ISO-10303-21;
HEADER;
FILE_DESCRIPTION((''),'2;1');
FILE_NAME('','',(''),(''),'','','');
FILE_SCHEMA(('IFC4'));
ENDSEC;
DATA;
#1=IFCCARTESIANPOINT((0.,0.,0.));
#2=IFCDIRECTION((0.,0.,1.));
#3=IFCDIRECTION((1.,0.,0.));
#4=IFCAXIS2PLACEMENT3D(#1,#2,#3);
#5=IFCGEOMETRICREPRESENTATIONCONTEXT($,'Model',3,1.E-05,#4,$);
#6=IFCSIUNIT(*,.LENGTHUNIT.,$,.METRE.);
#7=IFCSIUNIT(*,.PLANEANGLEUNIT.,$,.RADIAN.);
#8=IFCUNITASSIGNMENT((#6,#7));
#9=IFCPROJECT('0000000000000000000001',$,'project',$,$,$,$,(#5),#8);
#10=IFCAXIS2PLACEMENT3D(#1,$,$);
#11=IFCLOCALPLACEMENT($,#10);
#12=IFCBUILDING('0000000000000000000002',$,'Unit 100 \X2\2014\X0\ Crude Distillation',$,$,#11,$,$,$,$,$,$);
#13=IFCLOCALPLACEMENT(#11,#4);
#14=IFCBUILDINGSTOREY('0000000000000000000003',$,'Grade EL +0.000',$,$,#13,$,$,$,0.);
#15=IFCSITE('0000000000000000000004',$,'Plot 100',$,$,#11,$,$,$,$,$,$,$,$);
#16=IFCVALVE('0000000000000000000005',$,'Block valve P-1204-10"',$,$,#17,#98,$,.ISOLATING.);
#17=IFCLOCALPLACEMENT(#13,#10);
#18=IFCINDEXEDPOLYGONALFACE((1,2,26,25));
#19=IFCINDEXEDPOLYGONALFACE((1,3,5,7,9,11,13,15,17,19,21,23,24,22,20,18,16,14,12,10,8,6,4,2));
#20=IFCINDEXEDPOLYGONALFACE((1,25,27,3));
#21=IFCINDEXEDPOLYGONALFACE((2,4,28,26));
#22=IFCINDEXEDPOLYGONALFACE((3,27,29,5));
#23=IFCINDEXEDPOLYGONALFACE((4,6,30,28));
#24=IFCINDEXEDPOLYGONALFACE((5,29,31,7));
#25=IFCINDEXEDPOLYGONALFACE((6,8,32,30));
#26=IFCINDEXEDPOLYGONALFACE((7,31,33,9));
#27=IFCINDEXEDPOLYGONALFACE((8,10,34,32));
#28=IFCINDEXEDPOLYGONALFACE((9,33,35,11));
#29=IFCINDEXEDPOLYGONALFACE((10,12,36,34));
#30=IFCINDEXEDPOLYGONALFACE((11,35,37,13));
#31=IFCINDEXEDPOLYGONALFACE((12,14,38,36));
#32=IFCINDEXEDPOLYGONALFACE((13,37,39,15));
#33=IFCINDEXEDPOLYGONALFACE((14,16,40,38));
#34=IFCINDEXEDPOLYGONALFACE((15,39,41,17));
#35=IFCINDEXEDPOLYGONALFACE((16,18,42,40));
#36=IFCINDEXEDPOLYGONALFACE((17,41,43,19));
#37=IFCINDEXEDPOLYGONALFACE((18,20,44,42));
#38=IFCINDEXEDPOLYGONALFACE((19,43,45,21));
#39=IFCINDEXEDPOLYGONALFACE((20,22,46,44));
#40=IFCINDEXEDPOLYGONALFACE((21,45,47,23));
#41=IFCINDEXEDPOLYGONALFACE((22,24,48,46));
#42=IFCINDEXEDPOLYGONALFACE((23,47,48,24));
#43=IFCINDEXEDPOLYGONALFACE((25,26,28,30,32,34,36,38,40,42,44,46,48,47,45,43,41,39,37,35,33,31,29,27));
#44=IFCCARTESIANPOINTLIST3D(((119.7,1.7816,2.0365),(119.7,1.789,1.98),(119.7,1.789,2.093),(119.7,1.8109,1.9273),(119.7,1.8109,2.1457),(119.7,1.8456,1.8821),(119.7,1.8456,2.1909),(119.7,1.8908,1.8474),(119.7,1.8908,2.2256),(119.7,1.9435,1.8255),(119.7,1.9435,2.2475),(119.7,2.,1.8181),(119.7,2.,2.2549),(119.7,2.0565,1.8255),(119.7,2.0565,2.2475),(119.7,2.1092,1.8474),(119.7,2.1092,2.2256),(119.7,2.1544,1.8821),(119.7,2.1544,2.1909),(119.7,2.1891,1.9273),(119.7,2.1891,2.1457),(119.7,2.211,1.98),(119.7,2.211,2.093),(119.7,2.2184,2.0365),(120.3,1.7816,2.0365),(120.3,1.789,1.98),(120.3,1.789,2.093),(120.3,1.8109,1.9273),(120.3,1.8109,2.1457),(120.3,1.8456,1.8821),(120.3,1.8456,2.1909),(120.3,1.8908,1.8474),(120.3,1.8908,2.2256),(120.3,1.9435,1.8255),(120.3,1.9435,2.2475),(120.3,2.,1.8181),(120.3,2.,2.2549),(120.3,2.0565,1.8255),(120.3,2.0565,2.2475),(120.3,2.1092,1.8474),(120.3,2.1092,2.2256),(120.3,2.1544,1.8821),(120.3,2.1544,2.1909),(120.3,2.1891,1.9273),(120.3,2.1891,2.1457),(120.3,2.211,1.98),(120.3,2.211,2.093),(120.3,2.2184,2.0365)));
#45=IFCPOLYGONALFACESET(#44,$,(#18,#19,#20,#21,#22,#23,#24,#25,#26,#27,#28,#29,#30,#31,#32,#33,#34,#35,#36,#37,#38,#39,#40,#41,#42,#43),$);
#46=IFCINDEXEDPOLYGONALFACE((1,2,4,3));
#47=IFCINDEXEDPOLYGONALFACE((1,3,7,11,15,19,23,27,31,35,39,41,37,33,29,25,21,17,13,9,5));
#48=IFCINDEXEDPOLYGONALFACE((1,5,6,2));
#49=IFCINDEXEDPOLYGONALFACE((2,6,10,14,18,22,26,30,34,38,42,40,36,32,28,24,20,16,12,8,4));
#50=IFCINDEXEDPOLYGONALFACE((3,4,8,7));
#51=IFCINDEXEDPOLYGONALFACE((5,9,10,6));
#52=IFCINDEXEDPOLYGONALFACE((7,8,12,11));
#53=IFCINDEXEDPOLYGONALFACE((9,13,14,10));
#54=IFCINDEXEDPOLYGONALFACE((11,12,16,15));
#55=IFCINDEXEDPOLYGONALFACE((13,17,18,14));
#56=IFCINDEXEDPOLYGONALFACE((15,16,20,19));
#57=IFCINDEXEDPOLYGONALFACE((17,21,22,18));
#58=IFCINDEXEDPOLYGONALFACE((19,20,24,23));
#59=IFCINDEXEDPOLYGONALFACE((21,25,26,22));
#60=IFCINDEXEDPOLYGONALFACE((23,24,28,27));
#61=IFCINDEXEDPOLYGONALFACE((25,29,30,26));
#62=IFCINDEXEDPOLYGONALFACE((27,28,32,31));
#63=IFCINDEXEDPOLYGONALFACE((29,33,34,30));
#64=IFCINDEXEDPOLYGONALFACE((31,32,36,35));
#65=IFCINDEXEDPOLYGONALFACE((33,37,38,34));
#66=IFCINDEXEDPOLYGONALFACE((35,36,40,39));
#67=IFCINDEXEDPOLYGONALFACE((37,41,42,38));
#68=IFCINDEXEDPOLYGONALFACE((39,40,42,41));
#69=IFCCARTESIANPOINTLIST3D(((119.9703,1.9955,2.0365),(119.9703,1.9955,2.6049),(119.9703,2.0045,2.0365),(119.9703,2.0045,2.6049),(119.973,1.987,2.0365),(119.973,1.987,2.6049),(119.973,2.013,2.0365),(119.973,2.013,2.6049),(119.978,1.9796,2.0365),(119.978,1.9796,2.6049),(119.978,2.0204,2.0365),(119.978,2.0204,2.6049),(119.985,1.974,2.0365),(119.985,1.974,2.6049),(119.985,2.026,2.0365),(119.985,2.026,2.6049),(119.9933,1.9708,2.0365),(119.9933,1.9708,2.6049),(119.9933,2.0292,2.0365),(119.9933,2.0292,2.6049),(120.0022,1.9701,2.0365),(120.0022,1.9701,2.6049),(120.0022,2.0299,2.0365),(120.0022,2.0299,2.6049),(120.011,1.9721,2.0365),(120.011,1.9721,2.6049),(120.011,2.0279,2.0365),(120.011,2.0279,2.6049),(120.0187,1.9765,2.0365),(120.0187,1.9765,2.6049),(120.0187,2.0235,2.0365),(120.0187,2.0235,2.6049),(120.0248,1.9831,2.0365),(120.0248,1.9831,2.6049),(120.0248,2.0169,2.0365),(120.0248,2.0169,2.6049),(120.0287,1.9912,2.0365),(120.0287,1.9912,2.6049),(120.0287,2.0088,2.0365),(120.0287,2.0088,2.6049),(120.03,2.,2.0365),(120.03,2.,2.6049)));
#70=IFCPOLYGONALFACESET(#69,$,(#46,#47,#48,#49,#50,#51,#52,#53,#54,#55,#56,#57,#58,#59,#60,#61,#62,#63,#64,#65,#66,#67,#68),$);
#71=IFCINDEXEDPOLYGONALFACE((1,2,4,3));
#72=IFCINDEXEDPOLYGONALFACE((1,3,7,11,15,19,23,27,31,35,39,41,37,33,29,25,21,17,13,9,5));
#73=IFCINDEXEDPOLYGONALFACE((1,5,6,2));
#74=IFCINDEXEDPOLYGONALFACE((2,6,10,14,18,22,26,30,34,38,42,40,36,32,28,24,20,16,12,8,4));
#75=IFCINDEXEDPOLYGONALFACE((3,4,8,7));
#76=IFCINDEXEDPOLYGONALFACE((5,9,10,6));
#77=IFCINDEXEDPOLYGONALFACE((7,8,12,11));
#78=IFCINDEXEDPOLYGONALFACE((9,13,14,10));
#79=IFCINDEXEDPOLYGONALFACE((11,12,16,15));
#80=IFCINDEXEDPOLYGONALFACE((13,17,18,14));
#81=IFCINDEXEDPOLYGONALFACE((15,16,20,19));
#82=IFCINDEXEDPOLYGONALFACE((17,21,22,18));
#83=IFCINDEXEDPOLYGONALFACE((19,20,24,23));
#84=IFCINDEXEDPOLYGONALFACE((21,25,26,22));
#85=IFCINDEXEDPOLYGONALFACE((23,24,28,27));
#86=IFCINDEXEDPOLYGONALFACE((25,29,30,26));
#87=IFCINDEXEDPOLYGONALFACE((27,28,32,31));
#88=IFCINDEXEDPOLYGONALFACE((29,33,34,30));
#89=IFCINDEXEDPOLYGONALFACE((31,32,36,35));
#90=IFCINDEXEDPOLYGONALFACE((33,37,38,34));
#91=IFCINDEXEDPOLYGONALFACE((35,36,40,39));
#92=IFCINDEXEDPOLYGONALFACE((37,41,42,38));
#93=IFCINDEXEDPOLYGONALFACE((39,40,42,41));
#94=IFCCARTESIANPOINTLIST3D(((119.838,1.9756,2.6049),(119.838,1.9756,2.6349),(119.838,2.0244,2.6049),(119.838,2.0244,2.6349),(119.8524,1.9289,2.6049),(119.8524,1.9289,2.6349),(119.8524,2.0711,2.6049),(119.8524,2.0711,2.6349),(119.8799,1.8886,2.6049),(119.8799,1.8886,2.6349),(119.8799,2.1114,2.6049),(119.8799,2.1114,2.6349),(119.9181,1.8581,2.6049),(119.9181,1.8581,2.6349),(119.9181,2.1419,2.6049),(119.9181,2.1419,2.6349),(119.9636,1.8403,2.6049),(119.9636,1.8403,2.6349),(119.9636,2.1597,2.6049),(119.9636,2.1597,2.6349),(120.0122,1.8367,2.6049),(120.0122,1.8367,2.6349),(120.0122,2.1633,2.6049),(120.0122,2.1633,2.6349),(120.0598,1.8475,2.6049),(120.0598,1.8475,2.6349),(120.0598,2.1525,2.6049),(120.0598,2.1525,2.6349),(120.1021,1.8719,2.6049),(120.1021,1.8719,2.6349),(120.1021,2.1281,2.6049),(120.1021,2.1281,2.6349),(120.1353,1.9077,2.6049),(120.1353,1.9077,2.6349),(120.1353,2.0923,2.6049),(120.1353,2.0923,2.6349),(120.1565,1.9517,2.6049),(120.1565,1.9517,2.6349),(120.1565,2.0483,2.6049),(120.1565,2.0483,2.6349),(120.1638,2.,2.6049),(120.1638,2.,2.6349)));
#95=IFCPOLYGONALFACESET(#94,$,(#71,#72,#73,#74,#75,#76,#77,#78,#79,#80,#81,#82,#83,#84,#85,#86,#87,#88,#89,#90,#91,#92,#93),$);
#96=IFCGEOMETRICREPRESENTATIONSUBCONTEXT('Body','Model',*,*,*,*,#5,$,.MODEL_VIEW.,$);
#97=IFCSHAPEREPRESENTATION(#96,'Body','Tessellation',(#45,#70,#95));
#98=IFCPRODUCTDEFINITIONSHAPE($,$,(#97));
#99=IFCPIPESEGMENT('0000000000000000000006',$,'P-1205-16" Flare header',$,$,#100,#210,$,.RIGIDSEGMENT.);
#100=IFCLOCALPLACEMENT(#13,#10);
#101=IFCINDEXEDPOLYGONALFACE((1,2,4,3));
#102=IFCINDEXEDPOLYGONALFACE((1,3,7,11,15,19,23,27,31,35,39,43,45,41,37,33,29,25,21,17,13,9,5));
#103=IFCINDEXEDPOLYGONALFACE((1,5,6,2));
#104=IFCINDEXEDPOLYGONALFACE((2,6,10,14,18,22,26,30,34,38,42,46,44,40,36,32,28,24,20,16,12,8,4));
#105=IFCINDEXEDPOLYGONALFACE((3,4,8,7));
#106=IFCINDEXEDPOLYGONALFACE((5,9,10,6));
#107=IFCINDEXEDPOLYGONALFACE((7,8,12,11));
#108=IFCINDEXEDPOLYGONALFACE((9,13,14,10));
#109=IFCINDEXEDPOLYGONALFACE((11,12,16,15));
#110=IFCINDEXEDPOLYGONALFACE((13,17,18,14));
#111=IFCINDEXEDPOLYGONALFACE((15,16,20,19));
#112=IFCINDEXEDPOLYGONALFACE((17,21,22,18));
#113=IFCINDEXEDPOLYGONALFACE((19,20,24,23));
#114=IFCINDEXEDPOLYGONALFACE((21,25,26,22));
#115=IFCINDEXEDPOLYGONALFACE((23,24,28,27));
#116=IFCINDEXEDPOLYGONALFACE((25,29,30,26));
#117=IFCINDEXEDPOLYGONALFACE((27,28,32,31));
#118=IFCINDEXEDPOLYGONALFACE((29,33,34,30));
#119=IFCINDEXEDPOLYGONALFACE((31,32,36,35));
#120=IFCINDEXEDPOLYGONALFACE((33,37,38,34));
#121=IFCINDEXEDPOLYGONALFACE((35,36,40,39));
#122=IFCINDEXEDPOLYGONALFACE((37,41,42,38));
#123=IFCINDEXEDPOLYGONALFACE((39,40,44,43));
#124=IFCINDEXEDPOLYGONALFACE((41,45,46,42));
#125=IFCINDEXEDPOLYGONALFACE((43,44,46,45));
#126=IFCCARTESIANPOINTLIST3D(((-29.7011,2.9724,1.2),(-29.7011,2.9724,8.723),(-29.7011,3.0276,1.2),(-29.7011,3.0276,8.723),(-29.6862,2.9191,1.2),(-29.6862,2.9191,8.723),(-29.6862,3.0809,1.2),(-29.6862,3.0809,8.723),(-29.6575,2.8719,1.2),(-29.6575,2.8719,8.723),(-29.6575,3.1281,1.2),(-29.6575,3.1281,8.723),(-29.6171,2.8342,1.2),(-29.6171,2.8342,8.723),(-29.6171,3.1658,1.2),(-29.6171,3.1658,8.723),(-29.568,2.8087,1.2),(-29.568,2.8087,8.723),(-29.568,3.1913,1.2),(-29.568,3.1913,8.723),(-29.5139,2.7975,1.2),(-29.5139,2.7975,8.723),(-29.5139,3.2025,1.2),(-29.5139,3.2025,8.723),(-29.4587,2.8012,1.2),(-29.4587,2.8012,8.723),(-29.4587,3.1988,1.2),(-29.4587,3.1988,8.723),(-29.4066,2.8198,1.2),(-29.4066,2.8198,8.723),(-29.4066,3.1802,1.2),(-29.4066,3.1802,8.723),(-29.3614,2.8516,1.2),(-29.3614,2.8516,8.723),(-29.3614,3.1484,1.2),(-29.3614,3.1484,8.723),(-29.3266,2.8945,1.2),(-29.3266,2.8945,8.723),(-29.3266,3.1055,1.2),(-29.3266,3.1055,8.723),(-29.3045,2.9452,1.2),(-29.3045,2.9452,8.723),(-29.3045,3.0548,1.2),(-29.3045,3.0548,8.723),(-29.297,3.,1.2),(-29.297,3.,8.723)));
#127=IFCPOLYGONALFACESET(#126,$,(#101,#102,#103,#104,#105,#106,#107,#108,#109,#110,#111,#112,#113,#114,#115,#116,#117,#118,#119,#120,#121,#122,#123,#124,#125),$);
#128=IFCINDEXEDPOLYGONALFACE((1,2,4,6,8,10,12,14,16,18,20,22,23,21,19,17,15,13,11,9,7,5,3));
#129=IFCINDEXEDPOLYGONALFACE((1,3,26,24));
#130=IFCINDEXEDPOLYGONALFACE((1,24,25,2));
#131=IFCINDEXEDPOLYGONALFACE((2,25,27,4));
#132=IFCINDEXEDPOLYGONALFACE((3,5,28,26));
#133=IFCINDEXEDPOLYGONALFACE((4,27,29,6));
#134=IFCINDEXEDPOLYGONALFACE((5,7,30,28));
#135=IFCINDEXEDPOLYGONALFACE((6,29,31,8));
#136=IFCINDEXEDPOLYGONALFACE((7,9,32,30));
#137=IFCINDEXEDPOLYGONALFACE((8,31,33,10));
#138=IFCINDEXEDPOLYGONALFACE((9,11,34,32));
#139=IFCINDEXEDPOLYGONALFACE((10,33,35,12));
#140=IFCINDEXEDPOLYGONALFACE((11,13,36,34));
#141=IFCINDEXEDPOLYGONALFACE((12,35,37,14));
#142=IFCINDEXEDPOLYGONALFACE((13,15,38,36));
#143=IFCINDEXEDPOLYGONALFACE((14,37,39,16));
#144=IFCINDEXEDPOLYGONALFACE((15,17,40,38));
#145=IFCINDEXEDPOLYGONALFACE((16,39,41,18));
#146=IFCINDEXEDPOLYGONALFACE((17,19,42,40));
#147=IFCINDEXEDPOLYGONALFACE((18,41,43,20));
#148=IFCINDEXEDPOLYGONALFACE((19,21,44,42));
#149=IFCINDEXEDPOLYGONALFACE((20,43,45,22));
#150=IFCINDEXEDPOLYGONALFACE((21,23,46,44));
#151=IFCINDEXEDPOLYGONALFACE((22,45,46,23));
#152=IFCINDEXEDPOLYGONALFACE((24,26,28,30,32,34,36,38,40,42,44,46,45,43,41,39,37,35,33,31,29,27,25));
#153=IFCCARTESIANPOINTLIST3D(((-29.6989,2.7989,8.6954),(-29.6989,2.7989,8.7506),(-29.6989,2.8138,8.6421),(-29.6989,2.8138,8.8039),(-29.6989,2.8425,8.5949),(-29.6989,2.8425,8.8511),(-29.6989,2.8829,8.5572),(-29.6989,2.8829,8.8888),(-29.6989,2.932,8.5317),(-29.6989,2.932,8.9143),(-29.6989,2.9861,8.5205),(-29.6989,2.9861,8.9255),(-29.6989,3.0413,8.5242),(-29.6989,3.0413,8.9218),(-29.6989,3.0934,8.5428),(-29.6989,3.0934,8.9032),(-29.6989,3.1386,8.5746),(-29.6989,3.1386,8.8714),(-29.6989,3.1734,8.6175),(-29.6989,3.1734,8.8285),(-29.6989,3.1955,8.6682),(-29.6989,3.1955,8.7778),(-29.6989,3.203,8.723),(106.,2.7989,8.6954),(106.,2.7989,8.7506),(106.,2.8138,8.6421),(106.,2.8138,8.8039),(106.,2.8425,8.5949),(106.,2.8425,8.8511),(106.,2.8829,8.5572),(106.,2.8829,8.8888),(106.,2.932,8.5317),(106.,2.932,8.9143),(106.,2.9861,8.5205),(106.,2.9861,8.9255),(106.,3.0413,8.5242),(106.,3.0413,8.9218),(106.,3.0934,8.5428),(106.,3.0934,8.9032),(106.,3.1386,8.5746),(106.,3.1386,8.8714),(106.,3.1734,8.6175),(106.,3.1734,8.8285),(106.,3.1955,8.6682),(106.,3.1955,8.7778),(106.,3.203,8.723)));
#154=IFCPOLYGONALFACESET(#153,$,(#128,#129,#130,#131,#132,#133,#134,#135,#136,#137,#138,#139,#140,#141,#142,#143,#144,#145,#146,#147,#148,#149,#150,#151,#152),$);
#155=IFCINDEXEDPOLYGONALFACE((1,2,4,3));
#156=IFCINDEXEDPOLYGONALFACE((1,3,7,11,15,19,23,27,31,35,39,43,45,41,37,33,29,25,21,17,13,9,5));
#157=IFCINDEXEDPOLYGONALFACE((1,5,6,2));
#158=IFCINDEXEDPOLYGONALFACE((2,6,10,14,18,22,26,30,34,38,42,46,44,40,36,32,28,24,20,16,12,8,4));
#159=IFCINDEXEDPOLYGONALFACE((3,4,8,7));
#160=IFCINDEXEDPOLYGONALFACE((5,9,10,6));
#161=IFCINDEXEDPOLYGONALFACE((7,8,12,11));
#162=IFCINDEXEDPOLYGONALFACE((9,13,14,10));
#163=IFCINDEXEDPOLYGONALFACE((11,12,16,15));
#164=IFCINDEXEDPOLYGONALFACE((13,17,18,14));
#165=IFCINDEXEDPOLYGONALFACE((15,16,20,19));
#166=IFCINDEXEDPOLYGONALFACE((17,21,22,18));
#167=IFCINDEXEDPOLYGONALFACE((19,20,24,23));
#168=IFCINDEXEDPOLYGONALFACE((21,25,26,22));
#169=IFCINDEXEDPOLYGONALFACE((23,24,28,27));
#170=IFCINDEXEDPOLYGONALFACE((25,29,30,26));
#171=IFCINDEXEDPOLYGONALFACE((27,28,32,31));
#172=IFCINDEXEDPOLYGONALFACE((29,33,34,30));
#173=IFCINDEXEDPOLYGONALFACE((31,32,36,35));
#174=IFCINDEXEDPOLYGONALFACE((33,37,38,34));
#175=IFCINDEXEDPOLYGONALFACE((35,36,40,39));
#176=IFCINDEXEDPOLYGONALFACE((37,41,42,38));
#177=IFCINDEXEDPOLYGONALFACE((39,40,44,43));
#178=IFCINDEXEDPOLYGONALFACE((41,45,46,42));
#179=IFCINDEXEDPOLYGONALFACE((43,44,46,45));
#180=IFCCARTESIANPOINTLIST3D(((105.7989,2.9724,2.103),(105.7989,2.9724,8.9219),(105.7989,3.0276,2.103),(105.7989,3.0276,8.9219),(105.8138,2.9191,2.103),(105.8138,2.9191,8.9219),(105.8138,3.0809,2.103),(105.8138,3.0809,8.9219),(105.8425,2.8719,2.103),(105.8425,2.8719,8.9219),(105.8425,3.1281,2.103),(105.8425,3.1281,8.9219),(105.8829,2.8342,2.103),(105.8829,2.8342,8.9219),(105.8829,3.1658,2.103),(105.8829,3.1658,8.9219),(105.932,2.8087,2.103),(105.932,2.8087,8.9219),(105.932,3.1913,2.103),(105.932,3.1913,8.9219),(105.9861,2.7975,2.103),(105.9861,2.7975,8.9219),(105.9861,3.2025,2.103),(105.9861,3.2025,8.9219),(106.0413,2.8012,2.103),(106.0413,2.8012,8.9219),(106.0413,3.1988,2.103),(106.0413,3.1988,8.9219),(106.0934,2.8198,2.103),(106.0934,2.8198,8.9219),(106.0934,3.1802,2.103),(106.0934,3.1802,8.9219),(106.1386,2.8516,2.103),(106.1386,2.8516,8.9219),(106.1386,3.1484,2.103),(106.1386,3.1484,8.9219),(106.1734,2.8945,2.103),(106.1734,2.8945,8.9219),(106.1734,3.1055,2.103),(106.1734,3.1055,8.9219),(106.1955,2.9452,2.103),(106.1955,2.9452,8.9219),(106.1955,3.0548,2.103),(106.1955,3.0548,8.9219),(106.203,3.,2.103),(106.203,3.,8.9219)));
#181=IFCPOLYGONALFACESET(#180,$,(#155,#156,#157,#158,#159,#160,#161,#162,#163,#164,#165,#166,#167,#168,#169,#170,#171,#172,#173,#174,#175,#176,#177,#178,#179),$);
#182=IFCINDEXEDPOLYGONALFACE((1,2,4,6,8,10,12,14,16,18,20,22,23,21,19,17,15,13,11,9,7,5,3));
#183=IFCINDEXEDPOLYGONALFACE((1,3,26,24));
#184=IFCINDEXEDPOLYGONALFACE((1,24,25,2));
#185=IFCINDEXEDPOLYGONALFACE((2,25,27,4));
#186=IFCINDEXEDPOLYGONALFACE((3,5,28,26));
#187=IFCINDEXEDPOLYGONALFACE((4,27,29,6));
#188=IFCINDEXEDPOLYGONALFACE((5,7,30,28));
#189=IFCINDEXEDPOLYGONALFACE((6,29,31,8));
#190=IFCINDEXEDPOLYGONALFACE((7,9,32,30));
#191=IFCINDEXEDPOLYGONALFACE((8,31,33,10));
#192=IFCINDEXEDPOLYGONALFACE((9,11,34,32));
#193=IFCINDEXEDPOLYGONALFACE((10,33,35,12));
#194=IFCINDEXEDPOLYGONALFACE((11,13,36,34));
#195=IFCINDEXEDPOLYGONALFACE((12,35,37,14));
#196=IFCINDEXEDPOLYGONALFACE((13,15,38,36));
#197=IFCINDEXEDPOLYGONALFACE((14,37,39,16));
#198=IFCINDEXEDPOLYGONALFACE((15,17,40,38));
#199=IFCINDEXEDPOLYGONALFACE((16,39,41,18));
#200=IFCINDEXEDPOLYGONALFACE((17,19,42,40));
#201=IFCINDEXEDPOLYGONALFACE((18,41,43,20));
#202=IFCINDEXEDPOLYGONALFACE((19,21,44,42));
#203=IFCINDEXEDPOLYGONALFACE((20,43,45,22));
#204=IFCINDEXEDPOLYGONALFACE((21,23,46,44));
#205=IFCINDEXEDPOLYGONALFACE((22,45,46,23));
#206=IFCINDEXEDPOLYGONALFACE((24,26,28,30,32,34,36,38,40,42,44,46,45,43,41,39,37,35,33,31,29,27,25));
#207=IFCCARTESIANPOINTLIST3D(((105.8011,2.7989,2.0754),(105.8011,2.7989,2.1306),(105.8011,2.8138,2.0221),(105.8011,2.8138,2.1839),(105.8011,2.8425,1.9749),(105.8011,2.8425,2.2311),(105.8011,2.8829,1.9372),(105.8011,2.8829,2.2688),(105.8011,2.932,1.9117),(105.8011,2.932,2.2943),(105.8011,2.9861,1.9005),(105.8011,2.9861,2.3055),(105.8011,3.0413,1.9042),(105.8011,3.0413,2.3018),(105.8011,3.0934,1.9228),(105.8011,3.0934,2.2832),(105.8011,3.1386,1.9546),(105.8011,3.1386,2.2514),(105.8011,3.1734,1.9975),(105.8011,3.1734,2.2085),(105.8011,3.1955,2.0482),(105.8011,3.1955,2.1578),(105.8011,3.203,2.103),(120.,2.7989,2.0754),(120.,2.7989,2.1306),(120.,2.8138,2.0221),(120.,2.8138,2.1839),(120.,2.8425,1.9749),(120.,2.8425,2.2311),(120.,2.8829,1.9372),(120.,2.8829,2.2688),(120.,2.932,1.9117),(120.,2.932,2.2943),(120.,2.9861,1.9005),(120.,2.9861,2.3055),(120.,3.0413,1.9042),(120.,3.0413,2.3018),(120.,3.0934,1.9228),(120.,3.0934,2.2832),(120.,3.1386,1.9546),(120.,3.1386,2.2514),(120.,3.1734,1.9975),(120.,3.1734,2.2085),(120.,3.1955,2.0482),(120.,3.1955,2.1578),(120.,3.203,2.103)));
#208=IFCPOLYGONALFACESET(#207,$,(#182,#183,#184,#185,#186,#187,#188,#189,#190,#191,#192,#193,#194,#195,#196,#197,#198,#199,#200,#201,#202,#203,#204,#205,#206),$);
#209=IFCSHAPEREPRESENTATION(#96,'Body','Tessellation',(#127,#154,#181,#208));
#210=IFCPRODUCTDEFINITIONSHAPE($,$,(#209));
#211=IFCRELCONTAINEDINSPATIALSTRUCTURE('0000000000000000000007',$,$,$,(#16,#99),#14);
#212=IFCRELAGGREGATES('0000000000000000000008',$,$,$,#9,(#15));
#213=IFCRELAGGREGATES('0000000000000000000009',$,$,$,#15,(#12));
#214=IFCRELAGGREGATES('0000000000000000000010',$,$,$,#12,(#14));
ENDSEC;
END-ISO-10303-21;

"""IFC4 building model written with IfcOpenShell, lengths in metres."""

from ifc_helpers import new_model, si_unit, frame, origin, origin_with_axes, origin_2d, place, context, subcontext, project, spatial, circle, extrude, element, save


model = new_model("IFC4")

# Units and contexts
model_context = context("Model", 3, precision=1e-05, world=origin_with_axes())
body_context = subcontext(model_context, "Body", "Model", "MODEL_VIEW")
ifc_project = project(units=[si_unit("LENGTHUNIT", "METRE"), si_unit("PLANEANGLEUNIT", "RADIAN")], contexts=[model_context])

# Site, building, storey
placement = place(None, origin())
site = spatial("IfcSite", under=ifc_project, at=placement, Name="Plot 100")
building = spatial("IfcBuilding", under=site, at=placement, Name="Unit 100 — Crude Distillation")
storey_placement = place(placement, origin_with_axes())
storey = spatial("IfcBuildingStorey", under=building, at=storey_placement, Name="Grade EL +0.000", Elevation=0.0)

# Valve
valve_1_placement = place(storey_placement, origin_with_axes())
element("IfcValve", 1, at=valve_1_placement, inside=storey, Name="Block valve P-1204-10\"", PredefinedType="ISOLATING", context=body_context, shape_type="SweptSolid", body=[
    extrude(circle(Radius=0.2184, at=origin_2d()), frame((119.7, 2.0, 2.0365), z_axis=(1.0, 0.0, 0.0), x_axis=(0.0, 1.0, 0.0)), (0.0, 0.0, 1.0), 0.6),
    extrude(circle(Radius=0.03, at=origin_2d()), frame((120.0, 2.0, 2.0365), z_axis=(0.0, 0.0, 1.0), x_axis=(1.0, 0.0, 0.0)), (0.0, 0.0, 1.0), 0.5684),
    extrude(circle(Radius=0.1638, at=origin_2d()), frame((120.0, 2.0, 2.6049), z_axis=(0.0, 0.0, 1.0), x_axis=(1.0, 0.0, 0.0)), (0.0, 0.0, 1.0), 0.03),
])

# Pipe segment
pipe_segment_1_placement = place(storey_placement, origin_with_axes())
element("IfcPipeSegment", 2, at=pipe_segment_1_placement, inside=storey, Name="P-1205-16\" Flare header", PredefinedType="RIGIDSEGMENT", context=body_context, shape_type="SweptSolid", body=[
    extrude(circle(Radius=0.203, at=origin_2d()), frame((-29.5, 3.0, 1.2), z_axis=(0.0, 0.0, 1.0), x_axis=(1.0, 0.0, 0.0)), (0.0, 0.0, 1.0), 7.523),
    extrude(circle(Radius=0.203, at=origin_2d()), frame((-29.6989, 3.0, 8.723), z_axis=(1.0, 0.0, 0.0), x_axis=(0.0, 1.0, 0.0)), (0.0, 0.0, 1.0), 135.6989),
    extrude(circle(Radius=0.203, at=origin_2d()), frame((106.0, 3.0, 8.9219), z_axis=(0.0, 0.0, -1.0), x_axis=(1.0, 0.0, 0.0)), (0.0, 0.0, 1.0), 6.8189),
    extrude(circle(Radius=0.203, at=origin_2d()), frame((105.8011, 3.0, 2.103), z_axis=(1.0, 0.0, 0.0), x_axis=(0.0, 1.0, 0.0)), (0.0, 0.0, 1.0), 14.1989),
])

save(model, "model.ifc")
